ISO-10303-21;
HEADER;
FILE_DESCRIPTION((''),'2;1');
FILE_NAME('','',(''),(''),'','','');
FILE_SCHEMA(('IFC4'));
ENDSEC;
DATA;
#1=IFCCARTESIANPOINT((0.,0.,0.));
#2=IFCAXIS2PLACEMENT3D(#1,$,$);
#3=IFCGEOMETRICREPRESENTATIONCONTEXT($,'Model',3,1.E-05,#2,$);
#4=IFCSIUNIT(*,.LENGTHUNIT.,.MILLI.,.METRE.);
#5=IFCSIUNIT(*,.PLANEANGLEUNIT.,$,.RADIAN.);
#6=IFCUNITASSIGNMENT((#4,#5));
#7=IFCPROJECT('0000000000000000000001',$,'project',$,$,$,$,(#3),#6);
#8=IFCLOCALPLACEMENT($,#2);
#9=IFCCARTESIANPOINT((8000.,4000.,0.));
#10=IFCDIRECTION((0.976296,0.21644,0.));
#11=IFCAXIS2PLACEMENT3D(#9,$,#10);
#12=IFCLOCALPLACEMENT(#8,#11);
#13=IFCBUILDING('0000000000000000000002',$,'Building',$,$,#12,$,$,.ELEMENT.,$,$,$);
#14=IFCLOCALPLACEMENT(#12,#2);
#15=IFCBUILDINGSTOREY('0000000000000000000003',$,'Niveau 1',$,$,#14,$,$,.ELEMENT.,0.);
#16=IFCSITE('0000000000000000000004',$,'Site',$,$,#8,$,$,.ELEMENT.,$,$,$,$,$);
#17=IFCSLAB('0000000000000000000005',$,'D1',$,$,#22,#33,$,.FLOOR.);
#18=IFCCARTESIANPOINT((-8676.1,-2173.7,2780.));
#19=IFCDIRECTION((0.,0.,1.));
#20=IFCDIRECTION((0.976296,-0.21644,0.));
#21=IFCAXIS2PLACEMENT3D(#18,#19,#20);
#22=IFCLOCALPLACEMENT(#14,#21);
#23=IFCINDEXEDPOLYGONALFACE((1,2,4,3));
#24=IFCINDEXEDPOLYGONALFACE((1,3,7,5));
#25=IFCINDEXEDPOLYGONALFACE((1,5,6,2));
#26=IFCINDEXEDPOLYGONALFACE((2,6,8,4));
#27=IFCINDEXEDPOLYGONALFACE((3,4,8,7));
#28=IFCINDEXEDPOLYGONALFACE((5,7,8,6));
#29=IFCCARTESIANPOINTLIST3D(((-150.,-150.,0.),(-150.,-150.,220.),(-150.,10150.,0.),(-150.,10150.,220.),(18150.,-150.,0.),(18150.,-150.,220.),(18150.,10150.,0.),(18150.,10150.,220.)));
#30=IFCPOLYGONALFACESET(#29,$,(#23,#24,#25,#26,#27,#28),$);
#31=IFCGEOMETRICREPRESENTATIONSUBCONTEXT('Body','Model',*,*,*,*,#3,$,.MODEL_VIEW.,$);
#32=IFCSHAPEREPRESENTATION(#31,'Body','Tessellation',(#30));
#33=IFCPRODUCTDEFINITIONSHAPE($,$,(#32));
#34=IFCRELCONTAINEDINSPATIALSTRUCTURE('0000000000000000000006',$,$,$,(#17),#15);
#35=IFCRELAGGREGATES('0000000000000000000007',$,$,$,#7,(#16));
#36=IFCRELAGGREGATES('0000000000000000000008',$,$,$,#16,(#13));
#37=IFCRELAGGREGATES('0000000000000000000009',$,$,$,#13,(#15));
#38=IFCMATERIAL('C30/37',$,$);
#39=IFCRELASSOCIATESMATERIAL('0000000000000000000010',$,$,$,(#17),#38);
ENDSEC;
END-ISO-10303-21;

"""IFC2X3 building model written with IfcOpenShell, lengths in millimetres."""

from ifc_helpers import new_model, si_unit, frame, origin, place, context, subcontext, project, spatial, polyline, outline, extrude, material, element, save


model = new_model("IFC2X3")

# Units and contexts
model_context = context("Model", 3, precision=1e-05, world=origin())
body_context = subcontext(model_context, "Body", "Model", "MODEL_VIEW")
ifc_project = project(units=[si_unit("LENGTHUNIT", "METRE", prefix="MILLI"), si_unit("PLANEANGLEUNIT", "RADIAN")], contexts=[model_context])

# Site, building, storey
site_placement = place(None, origin())
site = spatial("IfcSite", under=ifc_project, at=site_placement, Name="Site", CompositionType="ELEMENT")
building_placement = place(site_placement, frame((8000.0, 4000.0, 0.0), x_axis=(0.976296, 0.21644, 0.0)))
building = spatial("IfcBuilding", under=site, at=building_placement, Name="Building", CompositionType="ELEMENT")
storey_placement = place(building_placement, origin())
storey = spatial("IfcBuildingStorey", under=building, at=storey_placement, Name="Niveau 1", CompositionType="ELEMENT", Elevation=0.0)

# Shared definitions
ifc_material = material(Name="C30/37")

# Slab
slab_placement = place(storey_placement, frame((-8676.1, -2173.7, 2780.0), z_axis=(0.0, 0.0, 1.0), x_axis=(0.976296, -0.21644, 0.0)))
element("IfcSlab", 1, at=slab_placement, inside=storey, material=ifc_material, Name="D1", PredefinedType="FLOOR", context=body_context, shape_type="SweptSolid", body=[
    extrude(outline(polyline([(-150.0, -150.0), (18150.0, -150.0), (18150.0, 10150.0), (-150.0, 10150.0), (-150.0, -150.0)])), origin(), (0.0, 0.0, 1.0), 220.0),
])

save(model, "model.ifc")
